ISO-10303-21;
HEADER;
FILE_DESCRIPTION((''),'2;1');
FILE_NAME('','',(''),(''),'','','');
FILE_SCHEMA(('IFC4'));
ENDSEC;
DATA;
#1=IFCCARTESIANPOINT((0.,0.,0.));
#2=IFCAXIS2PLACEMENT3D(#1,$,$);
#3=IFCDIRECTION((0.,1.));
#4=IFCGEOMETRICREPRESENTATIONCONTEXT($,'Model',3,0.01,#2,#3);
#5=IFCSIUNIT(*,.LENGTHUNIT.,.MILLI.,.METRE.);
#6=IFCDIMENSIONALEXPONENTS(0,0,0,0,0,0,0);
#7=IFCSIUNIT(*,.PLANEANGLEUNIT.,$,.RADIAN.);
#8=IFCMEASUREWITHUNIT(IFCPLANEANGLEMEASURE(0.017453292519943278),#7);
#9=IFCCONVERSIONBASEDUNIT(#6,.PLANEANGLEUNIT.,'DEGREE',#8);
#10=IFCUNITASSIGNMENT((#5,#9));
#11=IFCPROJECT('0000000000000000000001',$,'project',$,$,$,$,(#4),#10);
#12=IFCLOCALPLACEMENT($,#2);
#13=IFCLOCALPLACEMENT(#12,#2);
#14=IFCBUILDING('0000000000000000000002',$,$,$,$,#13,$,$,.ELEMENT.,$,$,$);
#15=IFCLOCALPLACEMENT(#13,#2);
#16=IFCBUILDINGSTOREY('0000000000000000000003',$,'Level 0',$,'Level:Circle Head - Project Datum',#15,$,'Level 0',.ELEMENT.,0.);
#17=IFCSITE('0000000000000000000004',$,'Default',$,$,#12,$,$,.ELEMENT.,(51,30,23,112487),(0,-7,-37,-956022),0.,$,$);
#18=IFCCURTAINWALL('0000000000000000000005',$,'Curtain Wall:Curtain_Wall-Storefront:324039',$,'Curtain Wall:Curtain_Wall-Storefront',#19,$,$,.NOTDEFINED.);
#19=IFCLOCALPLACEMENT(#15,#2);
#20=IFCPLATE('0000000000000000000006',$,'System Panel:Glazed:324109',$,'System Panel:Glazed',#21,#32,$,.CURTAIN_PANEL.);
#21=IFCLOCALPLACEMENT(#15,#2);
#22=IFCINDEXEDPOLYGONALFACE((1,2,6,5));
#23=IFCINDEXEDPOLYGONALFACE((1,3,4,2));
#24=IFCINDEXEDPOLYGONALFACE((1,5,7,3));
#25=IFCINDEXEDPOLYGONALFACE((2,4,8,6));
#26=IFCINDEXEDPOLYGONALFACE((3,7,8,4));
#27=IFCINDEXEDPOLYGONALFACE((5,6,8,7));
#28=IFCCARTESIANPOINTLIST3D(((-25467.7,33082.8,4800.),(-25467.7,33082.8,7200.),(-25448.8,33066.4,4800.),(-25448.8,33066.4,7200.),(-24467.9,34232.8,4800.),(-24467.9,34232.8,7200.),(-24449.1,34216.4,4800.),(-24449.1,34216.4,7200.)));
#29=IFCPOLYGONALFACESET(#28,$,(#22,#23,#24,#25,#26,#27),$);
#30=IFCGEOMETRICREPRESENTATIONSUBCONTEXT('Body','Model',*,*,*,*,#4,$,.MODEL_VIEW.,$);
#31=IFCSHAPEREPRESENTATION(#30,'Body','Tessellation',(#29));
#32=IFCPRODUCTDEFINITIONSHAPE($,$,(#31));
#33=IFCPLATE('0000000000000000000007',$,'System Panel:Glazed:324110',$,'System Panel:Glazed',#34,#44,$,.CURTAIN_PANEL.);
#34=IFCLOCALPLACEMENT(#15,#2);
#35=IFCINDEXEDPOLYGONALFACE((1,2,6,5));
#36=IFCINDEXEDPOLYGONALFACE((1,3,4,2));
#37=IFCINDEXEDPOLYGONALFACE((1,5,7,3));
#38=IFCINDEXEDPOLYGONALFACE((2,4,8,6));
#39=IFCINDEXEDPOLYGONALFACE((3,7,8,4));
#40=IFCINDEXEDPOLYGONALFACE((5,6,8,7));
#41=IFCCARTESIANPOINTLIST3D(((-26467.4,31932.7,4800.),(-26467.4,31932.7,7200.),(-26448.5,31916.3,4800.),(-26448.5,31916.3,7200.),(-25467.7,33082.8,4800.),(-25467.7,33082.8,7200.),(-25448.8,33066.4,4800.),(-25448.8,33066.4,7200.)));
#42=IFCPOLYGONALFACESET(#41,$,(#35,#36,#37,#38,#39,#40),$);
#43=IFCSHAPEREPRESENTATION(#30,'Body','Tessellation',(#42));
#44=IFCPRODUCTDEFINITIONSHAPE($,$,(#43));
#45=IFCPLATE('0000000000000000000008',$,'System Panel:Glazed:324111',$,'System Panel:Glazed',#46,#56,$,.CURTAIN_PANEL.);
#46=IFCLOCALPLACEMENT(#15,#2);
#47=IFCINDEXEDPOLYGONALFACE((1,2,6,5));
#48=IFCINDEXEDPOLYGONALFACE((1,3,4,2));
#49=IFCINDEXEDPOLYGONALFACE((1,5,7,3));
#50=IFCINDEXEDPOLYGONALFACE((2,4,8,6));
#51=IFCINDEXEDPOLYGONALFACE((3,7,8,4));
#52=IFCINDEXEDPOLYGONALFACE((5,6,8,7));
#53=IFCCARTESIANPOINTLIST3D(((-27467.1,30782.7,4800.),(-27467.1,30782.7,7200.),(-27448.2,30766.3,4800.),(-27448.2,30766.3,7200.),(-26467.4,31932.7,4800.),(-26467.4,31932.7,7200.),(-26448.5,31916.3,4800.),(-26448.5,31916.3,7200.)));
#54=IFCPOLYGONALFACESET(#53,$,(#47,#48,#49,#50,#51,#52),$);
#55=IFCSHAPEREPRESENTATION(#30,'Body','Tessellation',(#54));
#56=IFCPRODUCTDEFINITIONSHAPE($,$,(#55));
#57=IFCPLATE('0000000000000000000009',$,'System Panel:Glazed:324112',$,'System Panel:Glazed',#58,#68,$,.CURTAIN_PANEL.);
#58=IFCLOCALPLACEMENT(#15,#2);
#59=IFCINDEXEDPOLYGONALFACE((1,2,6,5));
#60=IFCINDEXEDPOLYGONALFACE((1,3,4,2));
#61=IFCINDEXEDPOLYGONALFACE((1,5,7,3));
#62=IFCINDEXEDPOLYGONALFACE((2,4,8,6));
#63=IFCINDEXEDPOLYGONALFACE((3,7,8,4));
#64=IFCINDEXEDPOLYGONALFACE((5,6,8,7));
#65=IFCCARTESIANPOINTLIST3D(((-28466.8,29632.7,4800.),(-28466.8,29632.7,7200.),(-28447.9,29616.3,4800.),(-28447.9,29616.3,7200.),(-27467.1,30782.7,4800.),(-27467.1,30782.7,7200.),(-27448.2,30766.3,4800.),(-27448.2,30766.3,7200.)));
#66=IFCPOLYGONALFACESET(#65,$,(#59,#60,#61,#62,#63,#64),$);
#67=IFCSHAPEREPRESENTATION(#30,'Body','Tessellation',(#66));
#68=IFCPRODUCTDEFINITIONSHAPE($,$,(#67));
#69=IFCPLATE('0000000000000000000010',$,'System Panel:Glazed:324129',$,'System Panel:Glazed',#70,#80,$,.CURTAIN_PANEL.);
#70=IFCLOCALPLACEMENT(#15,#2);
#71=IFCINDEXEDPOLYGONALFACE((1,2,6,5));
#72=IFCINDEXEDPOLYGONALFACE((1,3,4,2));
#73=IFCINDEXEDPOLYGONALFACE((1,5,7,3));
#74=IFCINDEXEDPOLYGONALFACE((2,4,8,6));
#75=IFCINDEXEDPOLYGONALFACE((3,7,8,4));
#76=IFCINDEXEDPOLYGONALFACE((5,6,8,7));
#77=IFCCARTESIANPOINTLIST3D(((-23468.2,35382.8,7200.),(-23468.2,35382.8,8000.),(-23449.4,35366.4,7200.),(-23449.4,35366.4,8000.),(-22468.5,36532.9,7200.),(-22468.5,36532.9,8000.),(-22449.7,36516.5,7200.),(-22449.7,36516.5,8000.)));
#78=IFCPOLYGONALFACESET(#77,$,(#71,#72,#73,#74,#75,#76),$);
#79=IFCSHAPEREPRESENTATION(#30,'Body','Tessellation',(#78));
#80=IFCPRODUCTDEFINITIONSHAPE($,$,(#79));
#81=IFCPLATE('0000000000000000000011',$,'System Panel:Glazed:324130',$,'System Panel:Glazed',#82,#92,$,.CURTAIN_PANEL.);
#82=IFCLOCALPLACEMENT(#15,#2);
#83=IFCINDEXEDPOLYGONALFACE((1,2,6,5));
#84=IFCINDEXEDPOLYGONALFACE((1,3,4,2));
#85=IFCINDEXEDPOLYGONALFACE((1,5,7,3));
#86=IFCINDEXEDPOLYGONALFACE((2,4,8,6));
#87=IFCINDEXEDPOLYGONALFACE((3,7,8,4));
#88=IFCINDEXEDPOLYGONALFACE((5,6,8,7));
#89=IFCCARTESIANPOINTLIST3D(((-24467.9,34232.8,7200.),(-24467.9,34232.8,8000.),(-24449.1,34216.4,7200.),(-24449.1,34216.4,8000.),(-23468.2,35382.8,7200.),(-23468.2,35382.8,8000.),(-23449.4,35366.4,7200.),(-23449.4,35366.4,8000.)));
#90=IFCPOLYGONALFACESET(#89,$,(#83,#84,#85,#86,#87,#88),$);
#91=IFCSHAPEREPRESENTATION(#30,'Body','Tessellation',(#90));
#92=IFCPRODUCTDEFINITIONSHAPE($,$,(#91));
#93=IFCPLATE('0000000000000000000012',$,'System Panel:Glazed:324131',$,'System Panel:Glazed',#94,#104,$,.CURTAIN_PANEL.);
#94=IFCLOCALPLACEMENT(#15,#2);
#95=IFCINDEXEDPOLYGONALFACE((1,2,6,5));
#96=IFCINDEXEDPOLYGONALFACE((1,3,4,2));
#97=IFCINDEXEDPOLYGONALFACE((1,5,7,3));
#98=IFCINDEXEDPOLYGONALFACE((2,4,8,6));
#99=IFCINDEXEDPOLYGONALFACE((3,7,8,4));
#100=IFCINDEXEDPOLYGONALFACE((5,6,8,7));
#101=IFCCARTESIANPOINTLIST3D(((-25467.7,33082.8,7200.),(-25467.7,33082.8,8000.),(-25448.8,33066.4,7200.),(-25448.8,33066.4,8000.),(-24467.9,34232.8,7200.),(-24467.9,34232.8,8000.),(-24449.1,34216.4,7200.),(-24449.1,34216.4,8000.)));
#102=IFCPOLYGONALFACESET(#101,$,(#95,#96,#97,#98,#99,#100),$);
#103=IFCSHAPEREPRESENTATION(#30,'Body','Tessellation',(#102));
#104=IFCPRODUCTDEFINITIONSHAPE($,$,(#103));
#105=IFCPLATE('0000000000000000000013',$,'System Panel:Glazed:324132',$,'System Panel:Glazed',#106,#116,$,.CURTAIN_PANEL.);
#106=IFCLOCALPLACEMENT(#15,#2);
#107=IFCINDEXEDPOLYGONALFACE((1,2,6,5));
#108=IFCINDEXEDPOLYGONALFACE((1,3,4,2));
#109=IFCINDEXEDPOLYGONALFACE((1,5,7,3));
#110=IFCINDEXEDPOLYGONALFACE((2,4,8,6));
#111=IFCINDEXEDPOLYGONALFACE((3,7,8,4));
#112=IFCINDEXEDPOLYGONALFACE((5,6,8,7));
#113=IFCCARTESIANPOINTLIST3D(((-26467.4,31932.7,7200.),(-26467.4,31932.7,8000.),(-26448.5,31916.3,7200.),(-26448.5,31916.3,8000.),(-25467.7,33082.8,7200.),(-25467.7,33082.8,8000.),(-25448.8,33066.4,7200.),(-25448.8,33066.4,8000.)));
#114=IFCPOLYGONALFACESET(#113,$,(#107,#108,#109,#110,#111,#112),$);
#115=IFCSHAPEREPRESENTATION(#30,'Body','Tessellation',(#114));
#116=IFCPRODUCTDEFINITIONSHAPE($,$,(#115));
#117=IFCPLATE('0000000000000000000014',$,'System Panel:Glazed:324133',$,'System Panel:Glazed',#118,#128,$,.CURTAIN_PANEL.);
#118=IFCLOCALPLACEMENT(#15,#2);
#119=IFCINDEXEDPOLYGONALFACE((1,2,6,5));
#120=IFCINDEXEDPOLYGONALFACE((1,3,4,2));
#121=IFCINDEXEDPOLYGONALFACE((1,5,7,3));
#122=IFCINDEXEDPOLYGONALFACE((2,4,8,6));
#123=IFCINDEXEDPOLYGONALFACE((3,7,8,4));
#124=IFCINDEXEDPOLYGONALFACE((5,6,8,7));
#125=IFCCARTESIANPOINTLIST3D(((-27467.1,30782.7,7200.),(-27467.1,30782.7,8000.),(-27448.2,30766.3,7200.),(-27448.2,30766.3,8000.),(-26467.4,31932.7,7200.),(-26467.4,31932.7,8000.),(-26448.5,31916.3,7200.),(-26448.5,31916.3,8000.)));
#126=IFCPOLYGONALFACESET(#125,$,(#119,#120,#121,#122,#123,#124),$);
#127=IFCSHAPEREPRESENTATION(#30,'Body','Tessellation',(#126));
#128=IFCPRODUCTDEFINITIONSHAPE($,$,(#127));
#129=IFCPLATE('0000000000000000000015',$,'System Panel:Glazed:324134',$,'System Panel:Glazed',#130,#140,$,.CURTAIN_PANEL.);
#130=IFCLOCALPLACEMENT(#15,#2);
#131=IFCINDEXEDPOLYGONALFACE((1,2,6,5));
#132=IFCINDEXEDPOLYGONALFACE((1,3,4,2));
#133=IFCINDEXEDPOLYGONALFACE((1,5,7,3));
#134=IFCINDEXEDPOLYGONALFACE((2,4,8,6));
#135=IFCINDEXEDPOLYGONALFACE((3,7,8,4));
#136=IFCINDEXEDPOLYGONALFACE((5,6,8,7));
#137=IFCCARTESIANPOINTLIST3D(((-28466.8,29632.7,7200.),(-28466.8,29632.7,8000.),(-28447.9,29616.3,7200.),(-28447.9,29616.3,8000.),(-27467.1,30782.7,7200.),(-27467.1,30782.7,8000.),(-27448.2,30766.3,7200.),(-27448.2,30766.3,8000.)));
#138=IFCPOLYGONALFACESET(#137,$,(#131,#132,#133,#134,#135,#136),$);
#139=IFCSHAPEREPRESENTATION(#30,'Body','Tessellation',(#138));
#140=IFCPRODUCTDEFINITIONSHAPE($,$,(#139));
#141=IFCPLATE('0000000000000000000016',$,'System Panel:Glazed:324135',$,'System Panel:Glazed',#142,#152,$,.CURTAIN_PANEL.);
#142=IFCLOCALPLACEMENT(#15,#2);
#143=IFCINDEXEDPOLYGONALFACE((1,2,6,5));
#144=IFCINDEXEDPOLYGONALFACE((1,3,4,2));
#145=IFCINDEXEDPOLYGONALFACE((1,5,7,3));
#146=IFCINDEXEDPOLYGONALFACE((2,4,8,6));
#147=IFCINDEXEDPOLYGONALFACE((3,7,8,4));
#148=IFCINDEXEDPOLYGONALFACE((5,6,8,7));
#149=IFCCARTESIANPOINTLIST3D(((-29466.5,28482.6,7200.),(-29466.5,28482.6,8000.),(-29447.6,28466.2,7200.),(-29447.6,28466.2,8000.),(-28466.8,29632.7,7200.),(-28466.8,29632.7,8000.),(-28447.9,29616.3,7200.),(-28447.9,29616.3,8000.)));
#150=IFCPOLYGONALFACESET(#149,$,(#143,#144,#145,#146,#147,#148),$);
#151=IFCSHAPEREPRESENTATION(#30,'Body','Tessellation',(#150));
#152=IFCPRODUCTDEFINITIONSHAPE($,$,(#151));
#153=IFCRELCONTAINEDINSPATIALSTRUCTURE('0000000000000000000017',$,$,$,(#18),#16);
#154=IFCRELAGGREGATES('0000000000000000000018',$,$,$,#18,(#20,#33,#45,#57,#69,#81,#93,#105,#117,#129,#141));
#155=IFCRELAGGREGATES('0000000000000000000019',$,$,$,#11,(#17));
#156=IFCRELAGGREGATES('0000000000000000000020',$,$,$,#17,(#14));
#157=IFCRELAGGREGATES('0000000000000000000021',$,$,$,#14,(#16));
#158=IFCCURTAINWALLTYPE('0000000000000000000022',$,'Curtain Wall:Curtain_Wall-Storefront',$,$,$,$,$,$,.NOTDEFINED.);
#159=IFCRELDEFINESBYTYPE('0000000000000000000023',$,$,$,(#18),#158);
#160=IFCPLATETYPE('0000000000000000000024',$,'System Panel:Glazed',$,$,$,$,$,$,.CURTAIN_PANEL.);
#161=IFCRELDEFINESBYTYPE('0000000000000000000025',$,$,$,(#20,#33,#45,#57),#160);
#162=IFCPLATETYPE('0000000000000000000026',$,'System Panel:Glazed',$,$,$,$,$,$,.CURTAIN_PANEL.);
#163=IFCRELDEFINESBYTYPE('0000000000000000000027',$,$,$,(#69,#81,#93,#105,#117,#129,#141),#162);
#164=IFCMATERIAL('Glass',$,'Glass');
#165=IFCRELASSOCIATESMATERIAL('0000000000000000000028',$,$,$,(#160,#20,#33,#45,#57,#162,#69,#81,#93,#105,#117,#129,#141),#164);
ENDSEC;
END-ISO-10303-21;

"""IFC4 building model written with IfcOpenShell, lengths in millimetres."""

from ifc_helpers import new_model, entity, si_unit, converted_unit, direction, frame, origin, place, context, subcontext, project, spatial, indexed_curve, outline, extrude, source, transform, mapped, material, type_object, type_shapes, element, aggregate, save


model = new_model("IFC4")

# Units and contexts
model_context = context("Model", 3, precision=0.01, world=origin(), true_north=direction((0.0, 1.0)))
body_context = subcontext(model_context, "Body", "Model", "MODEL_VIEW")
ifc_project = project(units=[si_unit("LENGTHUNIT", "METRE", prefix="MILLI"), converted_unit("PLANEANGLEUNIT", "DEGREE", entity("IfcPlaneAngleMeasure", 0.017453292519943278), si_unit("PLANEANGLEUNIT", "RADIAN"), dimensions=[0, 0, 0, 0, 0, 0, 0])], contexts=[model_context])

# Site, building, storey
site_placement = place(None, origin())
site = spatial("IfcSite", under=ifc_project, at=site_placement, Name="Default", CompositionType="ELEMENT", RefLatitude=(51, 30, 23, 112487), RefLongitude=(0, -7, -37, -956022), RefElevation=0.0)
building_placement = place(site_placement, origin())
building = spatial("IfcBuilding", under=site, at=building_placement, CompositionType="ELEMENT")
storey_placement = place(building_placement, origin())
storey = spatial("IfcBuildingStorey", under=building, at=storey_placement, Name="Level 0", ObjectType="Level:Circle Head - Project Datum", LongName="Level 0", CompositionType="ELEMENT", Elevation=0.0)

# Curtain wall, plates
curtain_wall_type = type_object("IfcCurtainWallType", Name="Curtain Wall:Curtain_Wall-Storefront", PredefinedType="NOTDEFINED")
curtain_wall_placement = place(storey_placement, origin())
curtain_wall = element("IfcCurtainWall", 1, at=curtain_wall_placement, inside=storey, type_object=curtain_wall_type, Name="Curtain Wall:Curtain_Wall-Storefront:324039", ObjectType="Curtain Wall:Curtain_Wall-Storefront", PredefinedType="NOTDEFINED")
ifc_material = material(Name="Glass", Category="Glass")
plate_type_1 = type_object("IfcPlateType", Name="System Panel:Glazed", PredefinedType="CURTAIN_PANEL", material=ifc_material)
shared_shape_1 = source(origin(), body_context, "Body", "SweptSolid", [
    extrude(outline(indexed_curve([(-12.5, -761.9), (12.5, -761.9), (12.5, 761.9), (-12.5, 761.9), (-12.5, -761.9)], self_intersect=False)), frame((0.0, 37.0, 0.0), z_axis=(0.0, 0.0, 1.0), x_axis=(0.0, 1.0, 0.0)), (0.0, 0.0, 1.0), 2400.0),
])
type_shapes(plate_type_1, [shared_shape_1])
plate_1_placement = place(curtain_wall_placement, frame((-24986.3, 33673.9, 4800.0), z_axis=(0.0, 0.0, 1.0), x_axis=(-0.656059, -0.75471, 0.0)))
plate_1 = element("IfcPlate", 2, at=plate_1_placement, type_object=plate_type_1, material=ifc_material, Name="System Panel:Glazed:324109", ObjectType="System Panel:Glazed", PredefinedType="CURTAIN_PANEL", context=body_context, shape_type="MappedRepresentation", body=[
    mapped(shared_shape_1, transform((0.0, 0.0, 0.0), scale=1.0)),
])
plate_2_placement = place(curtain_wall_placement, frame((-25986.0, 32523.8, 4800.0), z_axis=(0.0, 0.0, 1.0), x_axis=(-0.656059, -0.75471, 0.0)))
plate_2 = element("IfcPlate", 3, at=plate_2_placement, type_object=plate_type_1, material=ifc_material, Name="System Panel:Glazed:324110", ObjectType="System Panel:Glazed", PredefinedType="CURTAIN_PANEL", context=body_context, shape_type="MappedRepresentation", body=[
    mapped(shared_shape_1, transform((0.0, 0.0, 0.0), scale=1.0)),
])
plate_3_placement = place(curtain_wall_placement, frame((-26985.7, 31373.8, 4800.0), z_axis=(0.0, 0.0, 1.0), x_axis=(-0.656059, -0.75471, 0.0)))
plate_3 = element("IfcPlate", 4, at=plate_3_placement, type_object=plate_type_1, material=ifc_material, Name="System Panel:Glazed:324111", ObjectType="System Panel:Glazed", PredefinedType="CURTAIN_PANEL", context=body_context, shape_type="MappedRepresentation", body=[
    mapped(shared_shape_1, transform((0.0, 0.0, 0.0), scale=1.0)),
])
plate_4_placement = place(curtain_wall_placement, frame((-27985.4, 30223.8, 4800.0), z_axis=(0.0, 0.0, 1.0), x_axis=(-0.656059, -0.75471, 0.0)))
plate_4 = element("IfcPlate", 5, at=plate_4_placement, type_object=plate_type_1, material=ifc_material, Name="System Panel:Glazed:324112", ObjectType="System Panel:Glazed", PredefinedType="CURTAIN_PANEL", context=body_context, shape_type="MappedRepresentation", body=[
    mapped(shared_shape_1, transform((0.0, 0.0, 0.0), scale=1.0)),
])
plate_type_2 = type_object("IfcPlateType", Name="System Panel:Glazed", PredefinedType="CURTAIN_PANEL", material=ifc_material)
shared_shape_2 = source(origin(), body_context, "Body", "SweptSolid", [
    extrude(outline(indexed_curve([(-12.5, -761.9), (12.5, -761.9), (12.5, 761.9), (-12.5, 761.9), (-12.5, -761.9)], self_intersect=False)), frame((0.0, 37.0, 0.0), z_axis=(0.0, 0.0, 1.0), x_axis=(0.0, 1.0, 0.0)), (0.0, 0.0, 1.0), 800.0),
])
type_shapes(plate_type_2, [shared_shape_2])
plate_5_placement = place(curtain_wall_placement, frame((-22986.9, 35973.9, 7200.0), z_axis=(0.0, 0.0, 1.0), x_axis=(-0.656059, -0.75471, 0.0)))
plate_5 = element("IfcPlate", 6, at=plate_5_placement, type_object=plate_type_2, material=ifc_material, Name="System Panel:Glazed:324129", ObjectType="System Panel:Glazed", PredefinedType="CURTAIN_PANEL", context=body_context, shape_type="MappedRepresentation", body=[
    mapped(shared_shape_2, transform((0.0, 0.0, 0.0), scale=1.0)),
])
plate_6_placement = place(curtain_wall_placement, frame((-23986.6, 34823.9, 7200.0), z_axis=(0.0, 0.0, 1.0), x_axis=(-0.656059, -0.75471, 0.0)))
plate_6 = element("IfcPlate", 7, at=plate_6_placement, type_object=plate_type_2, material=ifc_material, Name="System Panel:Glazed:324130", ObjectType="System Panel:Glazed", PredefinedType="CURTAIN_PANEL", context=body_context, shape_type="MappedRepresentation", body=[
    mapped(shared_shape_2, transform((0.0, 0.0, 0.0), scale=1.0)),
])
plate_7_placement = place(curtain_wall_placement, frame((-24986.3, 33673.9, 7200.0), z_axis=(0.0, 0.0, 1.0), x_axis=(-0.656059, -0.75471, 0.0)))
plate_7 = element("IfcPlate", 8, at=plate_7_placement, type_object=plate_type_2, material=ifc_material, Name="System Panel:Glazed:324131", ObjectType="System Panel:Glazed", PredefinedType="CURTAIN_PANEL", context=body_context, shape_type="MappedRepresentation", body=[
    mapped(shared_shape_2, transform((0.0, 0.0, 0.0), scale=1.0)),
])
plate_8_placement = place(curtain_wall_placement, frame((-25986.0, 32523.8, 7200.0), z_axis=(0.0, 0.0, 1.0), x_axis=(-0.656059, -0.75471, 0.0)))
plate_8 = element("IfcPlate", 9, at=plate_8_placement, type_object=plate_type_2, material=ifc_material, Name="System Panel:Glazed:324132", ObjectType="System Panel:Glazed", PredefinedType="CURTAIN_PANEL", context=body_context, shape_type="MappedRepresentation", body=[
    mapped(shared_shape_2, transform((0.0, 0.0, 0.0), scale=1.0)),
])
plate_9_placement = place(curtain_wall_placement, frame((-26985.7, 31373.8, 7200.0), z_axis=(0.0, 0.0, 1.0), x_axis=(-0.656059, -0.75471, 0.0)))
plate_9 = element("IfcPlate", 10, at=plate_9_placement, type_object=plate_type_2, material=ifc_material, Name="System Panel:Glazed:324133", ObjectType="System Panel:Glazed", PredefinedType="CURTAIN_PANEL", context=body_context, shape_type="MappedRepresentation", body=[
    mapped(shared_shape_2, transform((0.0, 0.0, 0.0), scale=1.0)),
])
plate_10_placement = place(curtain_wall_placement, frame((-27985.4, 30223.8, 7200.0), z_axis=(0.0, 0.0, 1.0), x_axis=(-0.656059, -0.75471, 0.0)))
plate_10 = element("IfcPlate", 11, at=plate_10_placement, type_object=plate_type_2, material=ifc_material, Name="System Panel:Glazed:324134", ObjectType="System Panel:Glazed", PredefinedType="CURTAIN_PANEL", context=body_context, shape_type="MappedRepresentation", body=[
    mapped(shared_shape_2, transform((0.0, 0.0, 0.0), scale=1.0)),
])
plate_11_placement = place(curtain_wall_placement, frame((-28985.1, 29073.7, 7200.0), z_axis=(0.0, 0.0, 1.0), x_axis=(-0.656059, -0.75471, 0.0)))
plate_11 = element("IfcPlate", 12, at=plate_11_placement, type_object=plate_type_2, material=ifc_material, Name="System Panel:Glazed:324135", ObjectType="System Panel:Glazed", PredefinedType="CURTAIN_PANEL", context=body_context, shape_type="MappedRepresentation", body=[
    mapped(shared_shape_2, transform((0.0, 0.0, 0.0), scale=1.0)),
])
aggregate(curtain_wall, [plate_1, plate_2, plate_3, plate_4, plate_5, plate_6, plate_7, plate_8, plate_9, plate_10, plate_11])

save(model, "model.ifc")
